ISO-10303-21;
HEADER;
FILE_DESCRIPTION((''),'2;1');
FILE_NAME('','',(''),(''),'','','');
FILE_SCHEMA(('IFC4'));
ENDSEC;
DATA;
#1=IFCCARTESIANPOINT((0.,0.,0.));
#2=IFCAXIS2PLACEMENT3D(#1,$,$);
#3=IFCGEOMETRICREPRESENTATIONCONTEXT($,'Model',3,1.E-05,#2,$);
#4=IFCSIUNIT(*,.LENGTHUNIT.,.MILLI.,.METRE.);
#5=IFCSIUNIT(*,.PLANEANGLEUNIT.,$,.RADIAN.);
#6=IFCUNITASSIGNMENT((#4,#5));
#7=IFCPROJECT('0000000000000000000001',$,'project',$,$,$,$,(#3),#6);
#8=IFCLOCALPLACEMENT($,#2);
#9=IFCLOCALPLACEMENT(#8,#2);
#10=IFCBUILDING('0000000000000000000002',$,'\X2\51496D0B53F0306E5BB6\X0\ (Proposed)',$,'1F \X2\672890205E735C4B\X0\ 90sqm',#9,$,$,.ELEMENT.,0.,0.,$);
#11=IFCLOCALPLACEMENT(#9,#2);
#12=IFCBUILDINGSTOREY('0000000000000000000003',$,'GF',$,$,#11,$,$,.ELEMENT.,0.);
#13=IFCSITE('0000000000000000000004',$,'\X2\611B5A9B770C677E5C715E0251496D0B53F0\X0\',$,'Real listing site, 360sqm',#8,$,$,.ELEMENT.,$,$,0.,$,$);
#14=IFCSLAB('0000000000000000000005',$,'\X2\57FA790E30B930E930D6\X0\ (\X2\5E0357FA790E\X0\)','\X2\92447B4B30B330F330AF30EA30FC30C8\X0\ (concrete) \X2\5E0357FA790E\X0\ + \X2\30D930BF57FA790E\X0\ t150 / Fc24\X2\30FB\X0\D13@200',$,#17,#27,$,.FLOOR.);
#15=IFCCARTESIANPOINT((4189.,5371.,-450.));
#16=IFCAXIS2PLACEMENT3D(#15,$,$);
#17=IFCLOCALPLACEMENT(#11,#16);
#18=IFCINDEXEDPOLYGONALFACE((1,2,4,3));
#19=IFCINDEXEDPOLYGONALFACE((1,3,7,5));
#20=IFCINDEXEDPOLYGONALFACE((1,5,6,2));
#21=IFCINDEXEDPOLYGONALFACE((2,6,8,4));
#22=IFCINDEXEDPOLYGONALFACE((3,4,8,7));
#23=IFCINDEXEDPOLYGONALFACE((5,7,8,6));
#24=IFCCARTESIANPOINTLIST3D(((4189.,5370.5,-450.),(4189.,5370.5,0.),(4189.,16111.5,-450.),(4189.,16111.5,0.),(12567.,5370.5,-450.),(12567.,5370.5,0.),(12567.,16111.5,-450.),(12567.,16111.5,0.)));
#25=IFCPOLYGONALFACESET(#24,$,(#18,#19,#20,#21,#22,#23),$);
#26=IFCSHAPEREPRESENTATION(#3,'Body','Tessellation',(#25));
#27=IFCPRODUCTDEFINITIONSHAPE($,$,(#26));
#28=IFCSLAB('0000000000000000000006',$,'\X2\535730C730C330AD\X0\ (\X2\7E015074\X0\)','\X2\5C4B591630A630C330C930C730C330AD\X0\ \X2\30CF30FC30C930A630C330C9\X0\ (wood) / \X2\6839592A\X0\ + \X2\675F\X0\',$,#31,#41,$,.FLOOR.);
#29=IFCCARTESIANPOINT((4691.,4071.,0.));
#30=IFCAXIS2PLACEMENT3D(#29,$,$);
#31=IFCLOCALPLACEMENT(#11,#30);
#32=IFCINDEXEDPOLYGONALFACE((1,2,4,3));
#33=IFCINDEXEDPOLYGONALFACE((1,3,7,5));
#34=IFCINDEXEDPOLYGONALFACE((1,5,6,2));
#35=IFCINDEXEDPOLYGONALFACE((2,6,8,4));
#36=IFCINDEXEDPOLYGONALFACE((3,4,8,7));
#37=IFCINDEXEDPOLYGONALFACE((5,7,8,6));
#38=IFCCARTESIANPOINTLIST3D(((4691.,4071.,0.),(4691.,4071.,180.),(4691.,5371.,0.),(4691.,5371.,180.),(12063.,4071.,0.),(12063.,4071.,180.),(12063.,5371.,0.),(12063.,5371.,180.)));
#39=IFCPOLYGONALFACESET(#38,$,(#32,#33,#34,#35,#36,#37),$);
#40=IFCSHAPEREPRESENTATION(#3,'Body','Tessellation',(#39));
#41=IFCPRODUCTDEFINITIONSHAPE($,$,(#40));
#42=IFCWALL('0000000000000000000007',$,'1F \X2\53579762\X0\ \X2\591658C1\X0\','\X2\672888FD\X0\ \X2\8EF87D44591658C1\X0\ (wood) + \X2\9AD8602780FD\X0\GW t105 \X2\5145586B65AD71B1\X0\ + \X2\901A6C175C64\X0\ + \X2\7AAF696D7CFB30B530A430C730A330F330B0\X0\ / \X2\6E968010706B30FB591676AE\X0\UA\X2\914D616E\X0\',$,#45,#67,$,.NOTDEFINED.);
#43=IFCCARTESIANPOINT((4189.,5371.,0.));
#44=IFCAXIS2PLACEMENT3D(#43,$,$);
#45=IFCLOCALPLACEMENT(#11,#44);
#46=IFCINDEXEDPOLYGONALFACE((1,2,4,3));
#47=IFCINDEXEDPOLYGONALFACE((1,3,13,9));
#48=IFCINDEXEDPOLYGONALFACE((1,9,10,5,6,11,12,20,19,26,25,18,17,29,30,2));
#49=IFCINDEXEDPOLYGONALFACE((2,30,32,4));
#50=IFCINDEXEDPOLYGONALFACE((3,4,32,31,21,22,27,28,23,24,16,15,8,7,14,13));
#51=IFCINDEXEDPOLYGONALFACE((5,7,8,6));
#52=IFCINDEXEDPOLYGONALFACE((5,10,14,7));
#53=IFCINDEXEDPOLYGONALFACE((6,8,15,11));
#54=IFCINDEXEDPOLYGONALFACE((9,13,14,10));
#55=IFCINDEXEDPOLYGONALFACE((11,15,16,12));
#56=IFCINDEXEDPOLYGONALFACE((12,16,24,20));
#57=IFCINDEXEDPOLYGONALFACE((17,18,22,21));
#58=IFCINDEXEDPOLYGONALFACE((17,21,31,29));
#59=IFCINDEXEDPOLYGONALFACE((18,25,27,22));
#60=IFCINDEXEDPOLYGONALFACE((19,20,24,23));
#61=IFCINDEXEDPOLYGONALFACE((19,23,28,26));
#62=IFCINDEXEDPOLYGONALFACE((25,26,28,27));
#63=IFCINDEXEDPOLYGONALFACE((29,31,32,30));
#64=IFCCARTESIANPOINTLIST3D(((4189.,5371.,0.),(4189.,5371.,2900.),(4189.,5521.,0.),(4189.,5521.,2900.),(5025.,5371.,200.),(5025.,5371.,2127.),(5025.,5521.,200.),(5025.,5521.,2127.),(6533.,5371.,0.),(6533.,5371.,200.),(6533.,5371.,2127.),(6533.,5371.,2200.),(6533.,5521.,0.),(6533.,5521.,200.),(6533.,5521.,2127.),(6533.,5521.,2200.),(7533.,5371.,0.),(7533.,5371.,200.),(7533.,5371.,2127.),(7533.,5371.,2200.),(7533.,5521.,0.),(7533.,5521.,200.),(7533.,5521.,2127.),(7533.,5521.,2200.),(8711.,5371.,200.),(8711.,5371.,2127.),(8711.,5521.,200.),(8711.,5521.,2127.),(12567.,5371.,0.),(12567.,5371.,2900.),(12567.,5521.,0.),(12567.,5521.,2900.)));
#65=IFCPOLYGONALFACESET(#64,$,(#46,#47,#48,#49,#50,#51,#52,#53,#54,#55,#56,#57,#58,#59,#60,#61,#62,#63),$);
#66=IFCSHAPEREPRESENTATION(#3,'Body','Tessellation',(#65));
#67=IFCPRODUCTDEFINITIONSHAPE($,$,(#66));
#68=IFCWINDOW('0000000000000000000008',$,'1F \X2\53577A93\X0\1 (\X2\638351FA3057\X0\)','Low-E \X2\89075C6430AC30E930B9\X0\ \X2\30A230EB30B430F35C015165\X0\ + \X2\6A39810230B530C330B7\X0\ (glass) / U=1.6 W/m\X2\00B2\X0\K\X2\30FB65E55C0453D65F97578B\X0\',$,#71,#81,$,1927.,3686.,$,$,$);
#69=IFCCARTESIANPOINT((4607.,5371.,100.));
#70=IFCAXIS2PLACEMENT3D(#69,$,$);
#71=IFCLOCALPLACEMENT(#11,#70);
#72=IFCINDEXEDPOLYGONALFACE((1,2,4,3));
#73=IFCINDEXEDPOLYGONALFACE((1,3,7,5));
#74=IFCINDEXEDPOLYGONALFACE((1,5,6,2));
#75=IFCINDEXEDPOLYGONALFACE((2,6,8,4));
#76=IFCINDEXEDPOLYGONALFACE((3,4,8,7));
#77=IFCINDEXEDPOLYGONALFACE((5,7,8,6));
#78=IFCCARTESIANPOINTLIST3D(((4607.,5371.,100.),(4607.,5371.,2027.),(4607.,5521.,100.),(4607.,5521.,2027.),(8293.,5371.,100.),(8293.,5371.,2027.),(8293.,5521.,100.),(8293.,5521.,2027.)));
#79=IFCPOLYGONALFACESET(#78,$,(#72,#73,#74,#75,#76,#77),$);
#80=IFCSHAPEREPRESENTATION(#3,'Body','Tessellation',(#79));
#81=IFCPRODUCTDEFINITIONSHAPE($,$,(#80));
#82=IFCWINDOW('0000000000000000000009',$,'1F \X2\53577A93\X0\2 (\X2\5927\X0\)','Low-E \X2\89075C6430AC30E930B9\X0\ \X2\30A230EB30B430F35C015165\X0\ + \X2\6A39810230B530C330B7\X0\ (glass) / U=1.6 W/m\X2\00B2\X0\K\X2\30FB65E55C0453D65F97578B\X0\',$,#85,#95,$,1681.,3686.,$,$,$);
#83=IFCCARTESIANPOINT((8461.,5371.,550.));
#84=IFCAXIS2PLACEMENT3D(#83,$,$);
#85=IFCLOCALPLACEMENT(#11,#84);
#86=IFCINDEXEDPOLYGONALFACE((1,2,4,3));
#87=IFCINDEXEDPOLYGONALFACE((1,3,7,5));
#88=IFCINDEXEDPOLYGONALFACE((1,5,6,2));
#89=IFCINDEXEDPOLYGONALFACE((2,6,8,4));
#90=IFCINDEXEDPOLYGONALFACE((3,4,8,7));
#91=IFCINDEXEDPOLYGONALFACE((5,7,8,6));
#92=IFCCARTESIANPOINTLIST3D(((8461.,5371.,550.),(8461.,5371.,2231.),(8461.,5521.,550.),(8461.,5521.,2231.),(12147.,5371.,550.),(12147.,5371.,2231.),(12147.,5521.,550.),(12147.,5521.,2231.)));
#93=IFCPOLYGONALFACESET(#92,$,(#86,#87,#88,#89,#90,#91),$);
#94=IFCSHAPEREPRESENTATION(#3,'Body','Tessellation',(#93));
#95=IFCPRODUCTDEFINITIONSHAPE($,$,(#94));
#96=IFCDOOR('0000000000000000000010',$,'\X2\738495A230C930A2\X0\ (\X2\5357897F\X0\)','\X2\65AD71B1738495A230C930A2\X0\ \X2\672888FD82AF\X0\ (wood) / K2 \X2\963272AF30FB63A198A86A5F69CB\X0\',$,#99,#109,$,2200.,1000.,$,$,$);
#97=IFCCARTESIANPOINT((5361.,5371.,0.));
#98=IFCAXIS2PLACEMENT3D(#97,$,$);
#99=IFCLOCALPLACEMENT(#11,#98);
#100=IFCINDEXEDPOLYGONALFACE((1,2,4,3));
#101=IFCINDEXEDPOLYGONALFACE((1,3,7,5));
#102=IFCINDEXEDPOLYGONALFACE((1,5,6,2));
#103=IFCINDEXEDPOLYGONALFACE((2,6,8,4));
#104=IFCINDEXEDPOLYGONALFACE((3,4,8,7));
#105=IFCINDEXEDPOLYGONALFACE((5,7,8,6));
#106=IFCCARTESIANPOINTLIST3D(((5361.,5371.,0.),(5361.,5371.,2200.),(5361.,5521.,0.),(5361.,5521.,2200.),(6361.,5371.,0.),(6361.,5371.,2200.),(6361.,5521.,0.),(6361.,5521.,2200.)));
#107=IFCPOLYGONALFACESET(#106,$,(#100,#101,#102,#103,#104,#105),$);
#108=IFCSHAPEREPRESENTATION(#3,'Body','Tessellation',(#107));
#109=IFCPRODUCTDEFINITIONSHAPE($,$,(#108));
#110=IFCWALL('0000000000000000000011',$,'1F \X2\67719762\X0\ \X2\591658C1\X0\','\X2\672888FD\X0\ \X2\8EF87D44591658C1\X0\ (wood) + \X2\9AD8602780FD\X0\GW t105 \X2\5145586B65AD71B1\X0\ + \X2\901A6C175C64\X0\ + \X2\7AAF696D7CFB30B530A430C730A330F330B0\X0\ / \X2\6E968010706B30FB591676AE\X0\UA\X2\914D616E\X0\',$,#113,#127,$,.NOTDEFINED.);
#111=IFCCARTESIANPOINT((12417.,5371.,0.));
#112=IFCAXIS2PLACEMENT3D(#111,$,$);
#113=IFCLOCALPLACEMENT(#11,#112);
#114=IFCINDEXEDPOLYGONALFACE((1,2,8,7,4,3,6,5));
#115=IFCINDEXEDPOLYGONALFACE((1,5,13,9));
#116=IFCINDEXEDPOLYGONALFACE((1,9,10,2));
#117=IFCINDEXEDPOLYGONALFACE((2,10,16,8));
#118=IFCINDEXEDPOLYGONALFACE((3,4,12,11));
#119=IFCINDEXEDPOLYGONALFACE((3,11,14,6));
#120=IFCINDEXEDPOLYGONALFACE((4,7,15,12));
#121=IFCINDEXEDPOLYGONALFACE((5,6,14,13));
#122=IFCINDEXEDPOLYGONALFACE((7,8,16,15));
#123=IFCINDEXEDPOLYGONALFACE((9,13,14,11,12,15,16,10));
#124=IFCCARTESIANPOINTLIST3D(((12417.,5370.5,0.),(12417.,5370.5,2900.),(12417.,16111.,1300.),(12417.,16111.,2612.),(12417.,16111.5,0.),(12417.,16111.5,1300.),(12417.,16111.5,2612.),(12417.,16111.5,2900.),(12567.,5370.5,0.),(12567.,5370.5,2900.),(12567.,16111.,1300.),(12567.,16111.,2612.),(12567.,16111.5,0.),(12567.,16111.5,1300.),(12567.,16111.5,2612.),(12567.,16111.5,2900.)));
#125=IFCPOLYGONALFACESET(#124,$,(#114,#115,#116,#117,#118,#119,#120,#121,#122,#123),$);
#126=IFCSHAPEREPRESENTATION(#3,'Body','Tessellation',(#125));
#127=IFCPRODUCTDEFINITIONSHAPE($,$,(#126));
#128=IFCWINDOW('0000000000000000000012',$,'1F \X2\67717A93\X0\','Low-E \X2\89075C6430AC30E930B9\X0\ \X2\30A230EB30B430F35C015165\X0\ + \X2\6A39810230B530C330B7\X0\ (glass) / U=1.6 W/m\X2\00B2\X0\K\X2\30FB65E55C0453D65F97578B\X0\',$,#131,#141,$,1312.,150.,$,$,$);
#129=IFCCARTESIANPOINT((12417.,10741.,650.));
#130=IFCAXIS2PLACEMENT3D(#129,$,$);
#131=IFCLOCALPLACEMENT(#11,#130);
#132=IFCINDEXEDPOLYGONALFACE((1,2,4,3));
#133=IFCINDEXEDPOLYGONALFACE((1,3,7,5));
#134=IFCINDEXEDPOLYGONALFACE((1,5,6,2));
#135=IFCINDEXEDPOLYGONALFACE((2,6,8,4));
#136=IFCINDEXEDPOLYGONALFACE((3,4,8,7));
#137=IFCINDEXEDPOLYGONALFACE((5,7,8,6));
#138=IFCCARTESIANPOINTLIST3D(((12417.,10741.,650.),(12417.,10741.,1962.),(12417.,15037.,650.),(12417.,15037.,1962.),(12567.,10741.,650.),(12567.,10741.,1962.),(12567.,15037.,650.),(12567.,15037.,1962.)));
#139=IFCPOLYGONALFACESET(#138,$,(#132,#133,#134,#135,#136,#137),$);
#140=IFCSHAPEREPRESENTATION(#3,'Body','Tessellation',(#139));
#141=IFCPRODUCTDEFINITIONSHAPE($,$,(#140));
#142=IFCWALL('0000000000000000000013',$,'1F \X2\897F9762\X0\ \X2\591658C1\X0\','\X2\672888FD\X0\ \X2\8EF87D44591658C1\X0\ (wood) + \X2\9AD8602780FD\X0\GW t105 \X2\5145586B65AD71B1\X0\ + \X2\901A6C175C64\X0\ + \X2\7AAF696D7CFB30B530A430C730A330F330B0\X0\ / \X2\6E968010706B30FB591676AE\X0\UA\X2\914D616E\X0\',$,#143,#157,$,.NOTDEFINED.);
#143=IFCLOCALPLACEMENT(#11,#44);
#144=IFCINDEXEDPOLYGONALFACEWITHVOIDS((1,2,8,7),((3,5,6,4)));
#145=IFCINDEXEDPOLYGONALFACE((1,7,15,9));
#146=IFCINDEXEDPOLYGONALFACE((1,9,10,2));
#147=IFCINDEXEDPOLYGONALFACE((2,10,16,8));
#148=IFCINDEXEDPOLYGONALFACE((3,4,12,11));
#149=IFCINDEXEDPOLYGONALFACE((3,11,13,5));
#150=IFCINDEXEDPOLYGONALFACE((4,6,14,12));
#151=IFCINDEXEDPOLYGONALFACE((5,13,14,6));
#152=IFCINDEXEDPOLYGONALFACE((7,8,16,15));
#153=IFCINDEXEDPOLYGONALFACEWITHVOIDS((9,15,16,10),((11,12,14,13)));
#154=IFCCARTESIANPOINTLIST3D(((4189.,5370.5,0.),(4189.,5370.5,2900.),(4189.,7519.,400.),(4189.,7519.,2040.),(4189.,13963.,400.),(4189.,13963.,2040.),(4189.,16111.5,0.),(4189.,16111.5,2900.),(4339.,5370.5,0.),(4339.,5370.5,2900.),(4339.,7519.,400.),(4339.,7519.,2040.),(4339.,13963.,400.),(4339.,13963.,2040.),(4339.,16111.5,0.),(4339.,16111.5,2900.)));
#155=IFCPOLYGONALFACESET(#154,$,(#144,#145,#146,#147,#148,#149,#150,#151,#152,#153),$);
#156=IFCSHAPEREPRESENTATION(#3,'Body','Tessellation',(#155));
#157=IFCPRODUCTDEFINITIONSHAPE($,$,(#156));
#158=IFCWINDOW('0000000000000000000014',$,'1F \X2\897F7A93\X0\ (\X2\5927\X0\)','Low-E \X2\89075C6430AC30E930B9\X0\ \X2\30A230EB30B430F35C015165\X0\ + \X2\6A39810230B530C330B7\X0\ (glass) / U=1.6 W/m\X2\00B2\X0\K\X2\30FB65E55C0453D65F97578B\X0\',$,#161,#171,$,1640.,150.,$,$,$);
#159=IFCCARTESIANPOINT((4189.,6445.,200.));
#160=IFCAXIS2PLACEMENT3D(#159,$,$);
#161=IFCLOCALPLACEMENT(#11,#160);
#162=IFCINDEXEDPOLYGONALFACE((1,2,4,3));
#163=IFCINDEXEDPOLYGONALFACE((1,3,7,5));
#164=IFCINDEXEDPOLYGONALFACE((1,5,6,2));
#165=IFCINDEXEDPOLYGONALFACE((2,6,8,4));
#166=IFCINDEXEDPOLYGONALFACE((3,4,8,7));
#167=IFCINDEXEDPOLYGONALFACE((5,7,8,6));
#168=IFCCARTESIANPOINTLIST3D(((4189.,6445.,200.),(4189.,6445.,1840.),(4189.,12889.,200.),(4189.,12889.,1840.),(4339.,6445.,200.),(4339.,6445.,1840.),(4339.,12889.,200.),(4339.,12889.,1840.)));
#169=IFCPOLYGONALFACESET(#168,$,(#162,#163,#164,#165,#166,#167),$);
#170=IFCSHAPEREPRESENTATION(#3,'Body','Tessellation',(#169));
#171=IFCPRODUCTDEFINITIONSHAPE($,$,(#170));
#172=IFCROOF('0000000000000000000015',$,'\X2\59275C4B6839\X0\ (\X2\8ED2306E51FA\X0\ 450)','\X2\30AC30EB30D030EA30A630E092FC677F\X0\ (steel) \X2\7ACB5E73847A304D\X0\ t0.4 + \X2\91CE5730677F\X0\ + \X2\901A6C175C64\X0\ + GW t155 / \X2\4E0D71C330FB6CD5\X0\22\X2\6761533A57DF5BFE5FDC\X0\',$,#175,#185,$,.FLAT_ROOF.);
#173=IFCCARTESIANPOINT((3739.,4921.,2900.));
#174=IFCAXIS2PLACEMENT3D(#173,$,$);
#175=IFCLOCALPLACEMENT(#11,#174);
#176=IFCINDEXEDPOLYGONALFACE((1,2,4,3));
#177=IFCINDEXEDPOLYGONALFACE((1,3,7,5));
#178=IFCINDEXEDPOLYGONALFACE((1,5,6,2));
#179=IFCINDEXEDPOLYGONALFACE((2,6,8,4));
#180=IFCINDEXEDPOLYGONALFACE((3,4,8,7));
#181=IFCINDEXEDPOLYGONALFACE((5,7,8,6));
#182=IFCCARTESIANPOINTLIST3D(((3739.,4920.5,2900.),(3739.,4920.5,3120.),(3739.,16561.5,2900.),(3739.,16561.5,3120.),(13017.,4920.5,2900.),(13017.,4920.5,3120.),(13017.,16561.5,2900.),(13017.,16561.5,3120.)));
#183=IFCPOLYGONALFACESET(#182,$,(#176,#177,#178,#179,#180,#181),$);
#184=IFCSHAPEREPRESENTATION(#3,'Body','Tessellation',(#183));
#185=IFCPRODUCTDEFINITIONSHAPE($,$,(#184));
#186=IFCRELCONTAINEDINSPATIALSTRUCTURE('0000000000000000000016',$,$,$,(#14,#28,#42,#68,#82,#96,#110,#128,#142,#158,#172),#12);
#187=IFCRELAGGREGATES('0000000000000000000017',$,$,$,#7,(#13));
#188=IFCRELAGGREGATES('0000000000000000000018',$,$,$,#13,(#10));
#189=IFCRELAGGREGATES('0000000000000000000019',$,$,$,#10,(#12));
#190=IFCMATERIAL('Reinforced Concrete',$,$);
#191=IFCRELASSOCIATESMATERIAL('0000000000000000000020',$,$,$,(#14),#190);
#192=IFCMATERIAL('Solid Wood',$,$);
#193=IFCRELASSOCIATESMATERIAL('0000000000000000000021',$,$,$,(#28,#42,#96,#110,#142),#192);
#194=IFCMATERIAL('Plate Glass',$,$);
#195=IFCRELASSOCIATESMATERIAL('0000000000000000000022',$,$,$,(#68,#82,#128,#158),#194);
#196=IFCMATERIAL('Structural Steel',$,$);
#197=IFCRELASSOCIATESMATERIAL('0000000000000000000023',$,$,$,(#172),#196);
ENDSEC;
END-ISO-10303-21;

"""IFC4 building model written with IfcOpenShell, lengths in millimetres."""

from ifc_helpers import new_model, si_unit, frame, frame_2d, origin, place, context, project, spatial, rectangle, extrude, material, element, fill, save


model = new_model("IFC4")

# Units and contexts
model_context = context("Model", 3, precision=1e-05, world=origin())
ifc_project = project(units=[si_unit("LENGTHUNIT", "METRE", prefix="MILLI"), si_unit("PLANEANGLEUNIT", "RADIAN")], contexts=[model_context])

# Site, building, storey
site_placement = place(None, origin())
site = spatial("IfcSite", under=ifc_project, at=site_placement, Name="愛媛県松山市光洋台", ObjectType="Real listing site, 360sqm", CompositionType="ELEMENT", RefElevation=0.0)
building_placement = place(site_placement, origin())
building = spatial("IfcBuilding", under=site, at=building_placement, Name="光洋台の家 (Proposed)", ObjectType="1F 木造平屋 90sqm", CompositionType="ELEMENT", ElevationOfRefHeight=0.0, ElevationOfTerrain=0.0)
storey_placement = place(building_placement, origin())
storey = spatial("IfcBuildingStorey", under=building, at=storey_placement, Name="GF", CompositionType="ELEMENT", Elevation=0.0)

# Slabs
ifc_material_1 = material(Name="Reinforced Concrete")
slab_1_placement = place(storey_placement, frame((4189.0, 5371.0, -450.0)))
element("IfcSlab", 1, at=slab_1_placement, inside=storey, material=ifc_material_1, Name="基礎スラブ (布基礎)", Description="鉄筋コンクリート (concrete) 布基礎 + ベタ基礎 t150 / Fc24・D13@200", PredefinedType="FLOOR", context=model_context, shape_type="SweptSolid", body=[
    extrude(rectangle(XDim=8378.0, YDim=10741.0, at=frame_2d((4189.0, 5370.0))), frame((4189.0, 5371.0, -450.0)), (0.0, 0.0, 1.0), 450.0),
])
ifc_material_2 = material(Name="Solid Wood")
slab_2_placement = place(storey_placement, frame((4691.0, 4071.0, 0.0)))
element("IfcSlab", 2, at=slab_2_placement, inside=storey, material=ifc_material_2, Name="南デッキ (縁側)", Description="屋外ウッドデッキ ハードウッド (wood) / 根太 + 束", PredefinedType="FLOOR", context=model_context, shape_type="SweptSolid", body=[
    extrude(rectangle(XDim=7372.0, YDim=1300.0, at=frame_2d((3686.0, 650.0))), frame((4691.0, 4071.0, 0.0)), (0.0, 0.0, 1.0), 180.0),
])

# Wall, openings, windows, door
wall_1_placement = place(storey_placement, frame((4189.0, 5371.0, 0.0)))
wall_1 = element("IfcWall", 3, at=wall_1_placement, inside=storey, material=ifc_material_2, Name="1F 南面 外壁", Description="木製 軸組外壁 (wood) + 高性能GW t105 充填断熱 + 通気層 + 窯業系サイディング / 準耐火・外皮UA配慮", PredefinedType="NOTDEFINED", context=model_context, shape_type="SweptSolid", body=[
    extrude(rectangle(XDim=8378.0, YDim=150.0, at=frame_2d((4189.0, 75.0))), frame((4189.0, 5371.0, 0.0)), (0.0, 0.0, 1.0), 2900.0),
])
opening_1_placement = place(storey_placement, frame((4607.0, 5371.0, 100.0)))
opening_1 = element("IfcOpeningElement", 4, at=opening_1_placement, cuts=wall_1, PredefinedType="NOTDEFINED", context=model_context, shape_type="SweptSolid", body=[
    extrude(rectangle(XDim=3686.0, YDim=150.0, at=frame_2d((1843.0, 75.0))), frame((4607.0, 5371.0, 100.0)), (0.0, 0.0, 1.0), 1927.0),
])
opening_2_placement = place(storey_placement, frame((8461.0, 5371.0, 550.0)))
opening_2 = element("IfcOpeningElement", 5, at=opening_2_placement, cuts=wall_1, PredefinedType="NOTDEFINED", context=model_context, shape_type="SweptSolid", body=[
    extrude(rectangle(XDim=3686.0, YDim=150.0, at=frame_2d((1843.0, 75.0))), frame((8461.0, 5371.0, 550.0)), (0.0, 0.0, 1.0), 1681.0),
])
opening_3_placement = place(storey_placement, frame((5361.0, 5371.0, 0.0)))
opening_3 = element("IfcOpeningElement", 6, at=opening_3_placement, cuts=wall_1, PredefinedType="NOTDEFINED", context=model_context, shape_type="SweptSolid", body=[
    extrude(rectangle(XDim=1000.0, YDim=150.0, at=frame_2d((500.0, 75.0))), frame((5361.0, 5371.0, 0.0)), (0.0, 0.0, 1.0), 2200.0),
])
ifc_material_3 = material(Name="Plate Glass")
window_1_placement = place(storey_placement, frame((4607.0, 5371.0, 100.0)))
window_1 = element("IfcWindow", 7, at=window_1_placement, inside=storey, material=ifc_material_3, Name="1F 南窓1 (掃出し)", Description="Low-E 複層ガラス アルゴン封入 + 樹脂サッシ (glass) / U=1.6 W/m²K・日射取得型", OverallHeight=1927.0, OverallWidth=3686.0, context=model_context, shape_type="SweptSolid", body=[
    extrude(rectangle(XDim=3686.0, YDim=150.0, at=frame_2d((1843.0, 75.0))), frame((4607.0, 5371.0, 100.0)), (0.0, 0.0, 1.0), 1927.0),
])
fill(opening_1, window_1)
window_2_placement = place(storey_placement, frame((8461.0, 5371.0, 550.0)))
window_2 = element("IfcWindow", 8, at=window_2_placement, inside=storey, material=ifc_material_3, Name="1F 南窓2 (大)", Description="Low-E 複層ガラス アルゴン封入 + 樹脂サッシ (glass) / U=1.6 W/m²K・日射取得型", OverallHeight=1681.0, OverallWidth=3686.0, context=model_context, shape_type="SweptSolid", body=[
    extrude(rectangle(XDim=3686.0, YDim=150.0, at=frame_2d((1843.0, 75.0))), frame((8461.0, 5371.0, 550.0)), (0.0, 0.0, 1.0), 1681.0),
])
fill(opening_2, window_2)
door_placement = place(storey_placement, frame((5361.0, 5371.0, 0.0)))
door = element("IfcDoor", 9, at=door_placement, inside=storey, material=ifc_material_2, Name="玄関ドア (南西)", Description="断熱玄関ドア 木製芯 (wood) / K2 防犯・採風機構", OverallHeight=2200.0, OverallWidth=1000.0, context=model_context, shape_type="SweptSolid", body=[
    extrude(rectangle(XDim=1000.0, YDim=150.0, at=frame_2d((500.0, 75.0))), frame((5361.0, 5371.0, 0.0)), (0.0, 0.0, 1.0), 2200.0),
])
fill(opening_3, door)

# Walls, openings, windows
wall_2_placement = place(storey_placement, frame((12417.0, 5371.0, 0.0)))
wall_2 = element("IfcWall", 10, at=wall_2_placement, inside=storey, material=ifc_material_2, Name="1F 東面 外壁", Description="木製 軸組外壁 (wood) + 高性能GW t105 充填断熱 + 通気層 + 窯業系サイディング / 準耐火・外皮UA配慮", PredefinedType="NOTDEFINED", context=model_context, shape_type="SweptSolid", body=[
    extrude(rectangle(XDim=150.0, YDim=10741.0, at=frame_2d((75.0, 5370.0))), frame((12417.0, 5371.0, 0.0)), (0.0, 0.0, 1.0), 2900.0),
])
opening_4_placement = place(storey_placement, frame((12417.0, 10741.0, 650.0)))
opening_4 = element("IfcOpeningElement", 11, at=opening_4_placement, cuts=wall_2, PredefinedType="NOTDEFINED", context=model_context, shape_type="SweptSolid", body=[
    extrude(rectangle(XDim=150.0, YDim=4296.0, at=frame_2d((75.0, 2148.0))), frame((12417.0, 10741.0, 650.0)), (0.0, 0.0, 1.0), 1312.0),
])
window_3_placement = place(storey_placement, frame((12417.0, 10741.0, 650.0)))
window_3 = element("IfcWindow", 12, at=window_3_placement, inside=storey, material=ifc_material_3, Name="1F 東窓", Description="Low-E 複層ガラス アルゴン封入 + 樹脂サッシ (glass) / U=1.6 W/m²K・日射取得型", OverallHeight=1312.0, OverallWidth=150.0, context=model_context, shape_type="SweptSolid", body=[
    extrude(rectangle(XDim=150.0, YDim=4296.0, at=frame_2d((75.0, 2148.0))), frame((12417.0, 10741.0, 650.0)), (0.0, 0.0, 1.0), 1312.0),
])
fill(opening_4, window_3)
wall_3_placement = place(storey_placement, frame((4189.0, 5371.0, 0.0)))
wall_3 = element("IfcWall", 13, at=wall_3_placement, inside=storey, material=ifc_material_2, Name="1F 西面 外壁", Description="木製 軸組外壁 (wood) + 高性能GW t105 充填断熱 + 通気層 + 窯業系サイディング / 準耐火・外皮UA配慮", PredefinedType="NOTDEFINED", context=model_context, shape_type="SweptSolid", body=[
    extrude(rectangle(XDim=150.0, YDim=10741.0, at=frame_2d((75.0, 5370.0))), frame((4189.0, 5371.0, 0.0)), (0.0, 0.0, 1.0), 2900.0),
])
opening_5_placement = place(storey_placement, frame((4189.0, 6445.0, 200.0)))
opening_5 = element("IfcOpeningElement", 14, at=opening_5_placement, cuts=wall_3, PredefinedType="NOTDEFINED", context=model_context, shape_type="SweptSolid", body=[
    extrude(rectangle(XDim=150.0, YDim=6444.0, at=frame_2d((75.0, 3222.0))), frame((4189.0, 6445.0, 200.0)), (0.0, 0.0, 1.0), 1640.0),
])
window_4_placement = place(storey_placement, frame((4189.0, 6445.0, 200.0)))
window_4 = element("IfcWindow", 15, at=window_4_placement, inside=storey, material=ifc_material_3, Name="1F 西窓 (大)", Description="Low-E 複層ガラス アルゴン封入 + 樹脂サッシ (glass) / U=1.6 W/m²K・日射取得型", OverallHeight=1640.0, OverallWidth=150.0, context=model_context, shape_type="SweptSolid", body=[
    extrude(rectangle(XDim=150.0, YDim=6444.0, at=frame_2d((75.0, 3222.0))), frame((4189.0, 6445.0, 200.0)), (0.0, 0.0, 1.0), 1640.0),
])
fill(opening_5, window_4)

# Roof
ifc_material_4 = material(Name="Structural Steel")
roof_placement = place(storey_placement, frame((3739.0, 4921.0, 2900.0)))
element("IfcRoof", 16, at=roof_placement, inside=storey, material=ifc_material_4, Name="大屋根 (軒の出 450)", Description="ガルバリウム鋼板 (steel) 立平葺き t0.4 + 野地板 + 通気層 + GW t155 / 不燃・法22条区域対応", PredefinedType="FLAT_ROOF", context=model_context, shape_type="SweptSolid", body=[
    extrude(rectangle(XDim=9278.0, YDim=11641.0, at=frame_2d((4639.0, 5820.0))), frame((3739.0, 4921.0, 2900.0)), (0.0, 0.0, 1.0), 220.0),
])

save(model, "model.ifc")
